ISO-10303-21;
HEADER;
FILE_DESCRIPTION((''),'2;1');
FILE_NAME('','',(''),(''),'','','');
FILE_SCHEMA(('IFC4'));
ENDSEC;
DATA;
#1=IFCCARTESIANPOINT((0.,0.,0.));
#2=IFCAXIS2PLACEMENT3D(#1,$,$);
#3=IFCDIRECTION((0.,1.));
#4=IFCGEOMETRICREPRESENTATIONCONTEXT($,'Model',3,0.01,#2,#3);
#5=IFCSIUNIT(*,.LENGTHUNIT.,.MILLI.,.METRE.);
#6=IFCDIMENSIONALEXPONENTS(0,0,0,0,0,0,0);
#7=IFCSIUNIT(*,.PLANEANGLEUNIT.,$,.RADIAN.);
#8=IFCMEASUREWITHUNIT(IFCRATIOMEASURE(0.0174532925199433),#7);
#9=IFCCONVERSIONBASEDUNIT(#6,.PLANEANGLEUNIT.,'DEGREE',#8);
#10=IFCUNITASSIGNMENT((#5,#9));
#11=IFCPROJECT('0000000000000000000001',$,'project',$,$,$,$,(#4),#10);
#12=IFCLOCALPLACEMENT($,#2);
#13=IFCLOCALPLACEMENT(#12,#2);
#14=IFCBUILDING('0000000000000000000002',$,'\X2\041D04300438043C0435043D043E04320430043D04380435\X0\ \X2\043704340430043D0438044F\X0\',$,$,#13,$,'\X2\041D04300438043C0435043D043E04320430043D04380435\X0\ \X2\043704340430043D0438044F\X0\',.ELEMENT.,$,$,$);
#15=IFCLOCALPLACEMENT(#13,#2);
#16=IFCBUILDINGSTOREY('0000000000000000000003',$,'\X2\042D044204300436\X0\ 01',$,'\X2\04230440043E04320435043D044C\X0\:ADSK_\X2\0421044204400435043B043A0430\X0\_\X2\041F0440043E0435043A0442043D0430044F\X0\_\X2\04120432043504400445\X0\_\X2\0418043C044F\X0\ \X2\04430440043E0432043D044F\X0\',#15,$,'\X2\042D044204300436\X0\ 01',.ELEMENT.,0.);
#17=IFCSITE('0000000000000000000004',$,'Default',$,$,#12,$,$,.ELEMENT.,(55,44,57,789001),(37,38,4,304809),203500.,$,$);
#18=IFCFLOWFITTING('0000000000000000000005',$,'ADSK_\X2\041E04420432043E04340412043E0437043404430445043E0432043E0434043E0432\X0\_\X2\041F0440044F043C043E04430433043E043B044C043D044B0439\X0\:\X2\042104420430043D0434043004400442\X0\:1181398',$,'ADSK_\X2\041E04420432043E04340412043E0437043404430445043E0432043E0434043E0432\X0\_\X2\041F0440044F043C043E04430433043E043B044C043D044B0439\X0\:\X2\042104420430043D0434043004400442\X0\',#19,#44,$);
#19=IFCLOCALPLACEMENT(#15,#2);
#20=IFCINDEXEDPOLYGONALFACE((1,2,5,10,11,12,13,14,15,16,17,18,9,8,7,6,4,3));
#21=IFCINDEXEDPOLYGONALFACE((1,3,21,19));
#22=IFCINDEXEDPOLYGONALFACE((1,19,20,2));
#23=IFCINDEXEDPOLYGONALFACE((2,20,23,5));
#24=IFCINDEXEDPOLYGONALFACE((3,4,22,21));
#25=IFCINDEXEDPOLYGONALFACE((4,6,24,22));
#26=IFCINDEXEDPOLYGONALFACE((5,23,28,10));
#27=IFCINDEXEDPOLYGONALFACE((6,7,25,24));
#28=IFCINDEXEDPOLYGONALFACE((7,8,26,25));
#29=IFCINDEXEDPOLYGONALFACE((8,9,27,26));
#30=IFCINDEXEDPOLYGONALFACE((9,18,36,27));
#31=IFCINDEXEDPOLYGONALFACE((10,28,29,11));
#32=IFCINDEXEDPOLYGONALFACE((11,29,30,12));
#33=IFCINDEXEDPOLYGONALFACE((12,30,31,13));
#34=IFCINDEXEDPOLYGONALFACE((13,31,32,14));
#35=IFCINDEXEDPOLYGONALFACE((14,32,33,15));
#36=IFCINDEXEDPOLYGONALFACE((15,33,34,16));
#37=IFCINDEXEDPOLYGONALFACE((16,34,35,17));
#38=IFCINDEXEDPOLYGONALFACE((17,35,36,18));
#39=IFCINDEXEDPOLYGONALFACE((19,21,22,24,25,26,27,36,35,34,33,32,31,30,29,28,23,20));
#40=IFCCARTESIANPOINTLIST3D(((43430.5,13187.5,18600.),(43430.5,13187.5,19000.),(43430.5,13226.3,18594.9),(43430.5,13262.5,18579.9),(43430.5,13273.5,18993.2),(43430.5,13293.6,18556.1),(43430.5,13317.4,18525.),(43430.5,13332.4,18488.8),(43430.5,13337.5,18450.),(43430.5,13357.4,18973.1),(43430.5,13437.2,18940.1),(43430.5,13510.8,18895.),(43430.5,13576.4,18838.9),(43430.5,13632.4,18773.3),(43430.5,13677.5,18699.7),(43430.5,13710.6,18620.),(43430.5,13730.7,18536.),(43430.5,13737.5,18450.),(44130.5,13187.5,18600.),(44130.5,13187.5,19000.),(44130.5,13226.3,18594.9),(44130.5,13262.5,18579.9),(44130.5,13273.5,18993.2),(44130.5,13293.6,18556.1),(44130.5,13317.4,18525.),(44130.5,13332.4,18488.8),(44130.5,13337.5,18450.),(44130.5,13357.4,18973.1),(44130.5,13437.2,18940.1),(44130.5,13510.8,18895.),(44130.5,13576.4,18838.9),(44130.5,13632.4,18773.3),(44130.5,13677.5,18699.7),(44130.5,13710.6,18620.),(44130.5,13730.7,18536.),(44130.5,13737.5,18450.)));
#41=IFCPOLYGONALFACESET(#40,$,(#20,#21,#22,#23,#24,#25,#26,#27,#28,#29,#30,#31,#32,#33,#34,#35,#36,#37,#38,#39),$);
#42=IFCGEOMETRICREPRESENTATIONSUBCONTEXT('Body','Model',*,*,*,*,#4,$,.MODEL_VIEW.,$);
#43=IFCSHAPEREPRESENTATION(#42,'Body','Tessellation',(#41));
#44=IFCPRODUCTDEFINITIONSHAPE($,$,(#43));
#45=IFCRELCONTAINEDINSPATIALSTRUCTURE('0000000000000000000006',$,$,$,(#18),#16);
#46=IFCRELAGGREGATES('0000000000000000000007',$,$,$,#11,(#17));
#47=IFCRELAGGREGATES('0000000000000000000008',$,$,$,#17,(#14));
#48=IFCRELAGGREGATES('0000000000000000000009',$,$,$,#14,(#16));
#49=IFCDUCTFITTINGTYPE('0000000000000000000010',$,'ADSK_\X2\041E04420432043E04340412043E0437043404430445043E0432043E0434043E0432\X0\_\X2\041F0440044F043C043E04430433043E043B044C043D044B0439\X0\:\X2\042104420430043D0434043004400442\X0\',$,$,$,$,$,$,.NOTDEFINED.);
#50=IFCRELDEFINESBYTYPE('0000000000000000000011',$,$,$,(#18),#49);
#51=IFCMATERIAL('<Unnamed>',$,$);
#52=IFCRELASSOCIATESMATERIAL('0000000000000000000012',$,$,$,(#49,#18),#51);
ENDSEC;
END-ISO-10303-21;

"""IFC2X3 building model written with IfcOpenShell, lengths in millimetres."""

from ifc_helpers import new_model, entity, si_unit, converted_unit, direction, frame, frame_2d, origin, place, context, subcontext, project, spatial, polyline, circle_curve, parameter, trimmed, segment, composite_curve, outline, extrude, source, transform, mapped, material, type_object, type_shapes, element, save


model = new_model("IFC2X3")

# Units and contexts
model_context = context("Model", 3, precision=0.01, world=origin(), true_north=direction((0.0, 1.0)))
body_context = subcontext(model_context, "Body", "Model", "MODEL_VIEW")
ifc_project = project(units=[si_unit("LENGTHUNIT", "METRE", prefix="MILLI"), converted_unit("PLANEANGLEUNIT", "DEGREE", entity("IfcRatioMeasure", 0.0174532925199433), si_unit("PLANEANGLEUNIT", "RADIAN"), dimensions=[0, 0, 0, 0, 0, 0, 0])], contexts=[model_context])

# Site, building, storey
site_placement = place(None, origin())
site = spatial("IfcSite", under=ifc_project, at=site_placement, Name="Default", CompositionType="ELEMENT", RefLatitude=(55, 44, 57, 789001), RefLongitude=(37, 38, 4, 304809), RefElevation=203500.0)
building_placement = place(site_placement, origin())
building = spatial("IfcBuilding", under=site, at=building_placement, Name="Наименование здания", LongName="Наименование здания", CompositionType="ELEMENT")
storey_placement = place(building_placement, origin())
storey = spatial("IfcBuildingStorey", under=building, at=storey_placement, Name="Этаж 01", ObjectType="Уровень:ADSK_Стрелка_Проектная_Вверх_Имя уровня", LongName="Этаж 01", CompositionType="ELEMENT", Elevation=0.0)

# Shared definitions
ifc_material_1 = material(Name="<Unnamed>")

# Flow fitting
duct_fitting_type_1 = type_object("IfcDuctFittingType", Name="ADSK_ОтводВоздуховодов_Прямоугольный:Стандарт", PredefinedType="NOTDEFINED", material=ifc_material_1)
shared_shape_1 = source(origin(), body_context, "Body", "SweptSolid", [
    extrude(outline(composite_curve([segment(polyline([(-375.0, -175.0), (25.0, -175.0)]), True, "CONTINUOUS"), segment(trimmed(circle_curve(frame_2d((175.0, -175.0), x_axis=(0.0, 1.0)), 150.0), [parameter(0.0)], [parameter(90.0)], True, "PARAMETER"), False, "CONTINUOUS"), segment(polyline([(175.0, -25.0), (175.0, 375.0)]), True, "CONTINUOUS"), segment(trimmed(circle_curve(frame_2d((175.0, -175.0), x_axis=(0.0, 1.0)), 550.0), [parameter(0.0)], [parameter(90.0)], True, "PARAMETER"), True, "CONTINUOUS")], self_intersect=False)), frame((-175.0, 175.0, -350.0), z_axis=(0.0, 0.0, 1.0), x_axis=(-1.0, 0.0, 0.0)), (0.0, 0.0, 1.0), 700.0),
])
type_shapes(duct_fitting_type_1, [shared_shape_1])
flow_fitting_1_placement = place(storey_placement, frame((43780.5, 13537.5, 18800.0), z_axis=(1.0, 0.0, 0.0), x_axis=(0.0, 0.0, 1.0)))
element("IfcFlowFitting", 1, at=flow_fitting_1_placement, inside=storey, type_object=duct_fitting_type_1, material=ifc_material_1, Name="ADSK_ОтводВоздуховодов_Прямоугольный:Стандарт:1181398", ObjectType="ADSK_ОтводВоздуховодов_Прямоугольный:Стандарт", context=body_context, shape_type="MappedRepresentation", body=[
    mapped(shared_shape_1, transform((0.0, 0.0, 0.0), scale=1.0)),
])

save(model, "model.ifc")
